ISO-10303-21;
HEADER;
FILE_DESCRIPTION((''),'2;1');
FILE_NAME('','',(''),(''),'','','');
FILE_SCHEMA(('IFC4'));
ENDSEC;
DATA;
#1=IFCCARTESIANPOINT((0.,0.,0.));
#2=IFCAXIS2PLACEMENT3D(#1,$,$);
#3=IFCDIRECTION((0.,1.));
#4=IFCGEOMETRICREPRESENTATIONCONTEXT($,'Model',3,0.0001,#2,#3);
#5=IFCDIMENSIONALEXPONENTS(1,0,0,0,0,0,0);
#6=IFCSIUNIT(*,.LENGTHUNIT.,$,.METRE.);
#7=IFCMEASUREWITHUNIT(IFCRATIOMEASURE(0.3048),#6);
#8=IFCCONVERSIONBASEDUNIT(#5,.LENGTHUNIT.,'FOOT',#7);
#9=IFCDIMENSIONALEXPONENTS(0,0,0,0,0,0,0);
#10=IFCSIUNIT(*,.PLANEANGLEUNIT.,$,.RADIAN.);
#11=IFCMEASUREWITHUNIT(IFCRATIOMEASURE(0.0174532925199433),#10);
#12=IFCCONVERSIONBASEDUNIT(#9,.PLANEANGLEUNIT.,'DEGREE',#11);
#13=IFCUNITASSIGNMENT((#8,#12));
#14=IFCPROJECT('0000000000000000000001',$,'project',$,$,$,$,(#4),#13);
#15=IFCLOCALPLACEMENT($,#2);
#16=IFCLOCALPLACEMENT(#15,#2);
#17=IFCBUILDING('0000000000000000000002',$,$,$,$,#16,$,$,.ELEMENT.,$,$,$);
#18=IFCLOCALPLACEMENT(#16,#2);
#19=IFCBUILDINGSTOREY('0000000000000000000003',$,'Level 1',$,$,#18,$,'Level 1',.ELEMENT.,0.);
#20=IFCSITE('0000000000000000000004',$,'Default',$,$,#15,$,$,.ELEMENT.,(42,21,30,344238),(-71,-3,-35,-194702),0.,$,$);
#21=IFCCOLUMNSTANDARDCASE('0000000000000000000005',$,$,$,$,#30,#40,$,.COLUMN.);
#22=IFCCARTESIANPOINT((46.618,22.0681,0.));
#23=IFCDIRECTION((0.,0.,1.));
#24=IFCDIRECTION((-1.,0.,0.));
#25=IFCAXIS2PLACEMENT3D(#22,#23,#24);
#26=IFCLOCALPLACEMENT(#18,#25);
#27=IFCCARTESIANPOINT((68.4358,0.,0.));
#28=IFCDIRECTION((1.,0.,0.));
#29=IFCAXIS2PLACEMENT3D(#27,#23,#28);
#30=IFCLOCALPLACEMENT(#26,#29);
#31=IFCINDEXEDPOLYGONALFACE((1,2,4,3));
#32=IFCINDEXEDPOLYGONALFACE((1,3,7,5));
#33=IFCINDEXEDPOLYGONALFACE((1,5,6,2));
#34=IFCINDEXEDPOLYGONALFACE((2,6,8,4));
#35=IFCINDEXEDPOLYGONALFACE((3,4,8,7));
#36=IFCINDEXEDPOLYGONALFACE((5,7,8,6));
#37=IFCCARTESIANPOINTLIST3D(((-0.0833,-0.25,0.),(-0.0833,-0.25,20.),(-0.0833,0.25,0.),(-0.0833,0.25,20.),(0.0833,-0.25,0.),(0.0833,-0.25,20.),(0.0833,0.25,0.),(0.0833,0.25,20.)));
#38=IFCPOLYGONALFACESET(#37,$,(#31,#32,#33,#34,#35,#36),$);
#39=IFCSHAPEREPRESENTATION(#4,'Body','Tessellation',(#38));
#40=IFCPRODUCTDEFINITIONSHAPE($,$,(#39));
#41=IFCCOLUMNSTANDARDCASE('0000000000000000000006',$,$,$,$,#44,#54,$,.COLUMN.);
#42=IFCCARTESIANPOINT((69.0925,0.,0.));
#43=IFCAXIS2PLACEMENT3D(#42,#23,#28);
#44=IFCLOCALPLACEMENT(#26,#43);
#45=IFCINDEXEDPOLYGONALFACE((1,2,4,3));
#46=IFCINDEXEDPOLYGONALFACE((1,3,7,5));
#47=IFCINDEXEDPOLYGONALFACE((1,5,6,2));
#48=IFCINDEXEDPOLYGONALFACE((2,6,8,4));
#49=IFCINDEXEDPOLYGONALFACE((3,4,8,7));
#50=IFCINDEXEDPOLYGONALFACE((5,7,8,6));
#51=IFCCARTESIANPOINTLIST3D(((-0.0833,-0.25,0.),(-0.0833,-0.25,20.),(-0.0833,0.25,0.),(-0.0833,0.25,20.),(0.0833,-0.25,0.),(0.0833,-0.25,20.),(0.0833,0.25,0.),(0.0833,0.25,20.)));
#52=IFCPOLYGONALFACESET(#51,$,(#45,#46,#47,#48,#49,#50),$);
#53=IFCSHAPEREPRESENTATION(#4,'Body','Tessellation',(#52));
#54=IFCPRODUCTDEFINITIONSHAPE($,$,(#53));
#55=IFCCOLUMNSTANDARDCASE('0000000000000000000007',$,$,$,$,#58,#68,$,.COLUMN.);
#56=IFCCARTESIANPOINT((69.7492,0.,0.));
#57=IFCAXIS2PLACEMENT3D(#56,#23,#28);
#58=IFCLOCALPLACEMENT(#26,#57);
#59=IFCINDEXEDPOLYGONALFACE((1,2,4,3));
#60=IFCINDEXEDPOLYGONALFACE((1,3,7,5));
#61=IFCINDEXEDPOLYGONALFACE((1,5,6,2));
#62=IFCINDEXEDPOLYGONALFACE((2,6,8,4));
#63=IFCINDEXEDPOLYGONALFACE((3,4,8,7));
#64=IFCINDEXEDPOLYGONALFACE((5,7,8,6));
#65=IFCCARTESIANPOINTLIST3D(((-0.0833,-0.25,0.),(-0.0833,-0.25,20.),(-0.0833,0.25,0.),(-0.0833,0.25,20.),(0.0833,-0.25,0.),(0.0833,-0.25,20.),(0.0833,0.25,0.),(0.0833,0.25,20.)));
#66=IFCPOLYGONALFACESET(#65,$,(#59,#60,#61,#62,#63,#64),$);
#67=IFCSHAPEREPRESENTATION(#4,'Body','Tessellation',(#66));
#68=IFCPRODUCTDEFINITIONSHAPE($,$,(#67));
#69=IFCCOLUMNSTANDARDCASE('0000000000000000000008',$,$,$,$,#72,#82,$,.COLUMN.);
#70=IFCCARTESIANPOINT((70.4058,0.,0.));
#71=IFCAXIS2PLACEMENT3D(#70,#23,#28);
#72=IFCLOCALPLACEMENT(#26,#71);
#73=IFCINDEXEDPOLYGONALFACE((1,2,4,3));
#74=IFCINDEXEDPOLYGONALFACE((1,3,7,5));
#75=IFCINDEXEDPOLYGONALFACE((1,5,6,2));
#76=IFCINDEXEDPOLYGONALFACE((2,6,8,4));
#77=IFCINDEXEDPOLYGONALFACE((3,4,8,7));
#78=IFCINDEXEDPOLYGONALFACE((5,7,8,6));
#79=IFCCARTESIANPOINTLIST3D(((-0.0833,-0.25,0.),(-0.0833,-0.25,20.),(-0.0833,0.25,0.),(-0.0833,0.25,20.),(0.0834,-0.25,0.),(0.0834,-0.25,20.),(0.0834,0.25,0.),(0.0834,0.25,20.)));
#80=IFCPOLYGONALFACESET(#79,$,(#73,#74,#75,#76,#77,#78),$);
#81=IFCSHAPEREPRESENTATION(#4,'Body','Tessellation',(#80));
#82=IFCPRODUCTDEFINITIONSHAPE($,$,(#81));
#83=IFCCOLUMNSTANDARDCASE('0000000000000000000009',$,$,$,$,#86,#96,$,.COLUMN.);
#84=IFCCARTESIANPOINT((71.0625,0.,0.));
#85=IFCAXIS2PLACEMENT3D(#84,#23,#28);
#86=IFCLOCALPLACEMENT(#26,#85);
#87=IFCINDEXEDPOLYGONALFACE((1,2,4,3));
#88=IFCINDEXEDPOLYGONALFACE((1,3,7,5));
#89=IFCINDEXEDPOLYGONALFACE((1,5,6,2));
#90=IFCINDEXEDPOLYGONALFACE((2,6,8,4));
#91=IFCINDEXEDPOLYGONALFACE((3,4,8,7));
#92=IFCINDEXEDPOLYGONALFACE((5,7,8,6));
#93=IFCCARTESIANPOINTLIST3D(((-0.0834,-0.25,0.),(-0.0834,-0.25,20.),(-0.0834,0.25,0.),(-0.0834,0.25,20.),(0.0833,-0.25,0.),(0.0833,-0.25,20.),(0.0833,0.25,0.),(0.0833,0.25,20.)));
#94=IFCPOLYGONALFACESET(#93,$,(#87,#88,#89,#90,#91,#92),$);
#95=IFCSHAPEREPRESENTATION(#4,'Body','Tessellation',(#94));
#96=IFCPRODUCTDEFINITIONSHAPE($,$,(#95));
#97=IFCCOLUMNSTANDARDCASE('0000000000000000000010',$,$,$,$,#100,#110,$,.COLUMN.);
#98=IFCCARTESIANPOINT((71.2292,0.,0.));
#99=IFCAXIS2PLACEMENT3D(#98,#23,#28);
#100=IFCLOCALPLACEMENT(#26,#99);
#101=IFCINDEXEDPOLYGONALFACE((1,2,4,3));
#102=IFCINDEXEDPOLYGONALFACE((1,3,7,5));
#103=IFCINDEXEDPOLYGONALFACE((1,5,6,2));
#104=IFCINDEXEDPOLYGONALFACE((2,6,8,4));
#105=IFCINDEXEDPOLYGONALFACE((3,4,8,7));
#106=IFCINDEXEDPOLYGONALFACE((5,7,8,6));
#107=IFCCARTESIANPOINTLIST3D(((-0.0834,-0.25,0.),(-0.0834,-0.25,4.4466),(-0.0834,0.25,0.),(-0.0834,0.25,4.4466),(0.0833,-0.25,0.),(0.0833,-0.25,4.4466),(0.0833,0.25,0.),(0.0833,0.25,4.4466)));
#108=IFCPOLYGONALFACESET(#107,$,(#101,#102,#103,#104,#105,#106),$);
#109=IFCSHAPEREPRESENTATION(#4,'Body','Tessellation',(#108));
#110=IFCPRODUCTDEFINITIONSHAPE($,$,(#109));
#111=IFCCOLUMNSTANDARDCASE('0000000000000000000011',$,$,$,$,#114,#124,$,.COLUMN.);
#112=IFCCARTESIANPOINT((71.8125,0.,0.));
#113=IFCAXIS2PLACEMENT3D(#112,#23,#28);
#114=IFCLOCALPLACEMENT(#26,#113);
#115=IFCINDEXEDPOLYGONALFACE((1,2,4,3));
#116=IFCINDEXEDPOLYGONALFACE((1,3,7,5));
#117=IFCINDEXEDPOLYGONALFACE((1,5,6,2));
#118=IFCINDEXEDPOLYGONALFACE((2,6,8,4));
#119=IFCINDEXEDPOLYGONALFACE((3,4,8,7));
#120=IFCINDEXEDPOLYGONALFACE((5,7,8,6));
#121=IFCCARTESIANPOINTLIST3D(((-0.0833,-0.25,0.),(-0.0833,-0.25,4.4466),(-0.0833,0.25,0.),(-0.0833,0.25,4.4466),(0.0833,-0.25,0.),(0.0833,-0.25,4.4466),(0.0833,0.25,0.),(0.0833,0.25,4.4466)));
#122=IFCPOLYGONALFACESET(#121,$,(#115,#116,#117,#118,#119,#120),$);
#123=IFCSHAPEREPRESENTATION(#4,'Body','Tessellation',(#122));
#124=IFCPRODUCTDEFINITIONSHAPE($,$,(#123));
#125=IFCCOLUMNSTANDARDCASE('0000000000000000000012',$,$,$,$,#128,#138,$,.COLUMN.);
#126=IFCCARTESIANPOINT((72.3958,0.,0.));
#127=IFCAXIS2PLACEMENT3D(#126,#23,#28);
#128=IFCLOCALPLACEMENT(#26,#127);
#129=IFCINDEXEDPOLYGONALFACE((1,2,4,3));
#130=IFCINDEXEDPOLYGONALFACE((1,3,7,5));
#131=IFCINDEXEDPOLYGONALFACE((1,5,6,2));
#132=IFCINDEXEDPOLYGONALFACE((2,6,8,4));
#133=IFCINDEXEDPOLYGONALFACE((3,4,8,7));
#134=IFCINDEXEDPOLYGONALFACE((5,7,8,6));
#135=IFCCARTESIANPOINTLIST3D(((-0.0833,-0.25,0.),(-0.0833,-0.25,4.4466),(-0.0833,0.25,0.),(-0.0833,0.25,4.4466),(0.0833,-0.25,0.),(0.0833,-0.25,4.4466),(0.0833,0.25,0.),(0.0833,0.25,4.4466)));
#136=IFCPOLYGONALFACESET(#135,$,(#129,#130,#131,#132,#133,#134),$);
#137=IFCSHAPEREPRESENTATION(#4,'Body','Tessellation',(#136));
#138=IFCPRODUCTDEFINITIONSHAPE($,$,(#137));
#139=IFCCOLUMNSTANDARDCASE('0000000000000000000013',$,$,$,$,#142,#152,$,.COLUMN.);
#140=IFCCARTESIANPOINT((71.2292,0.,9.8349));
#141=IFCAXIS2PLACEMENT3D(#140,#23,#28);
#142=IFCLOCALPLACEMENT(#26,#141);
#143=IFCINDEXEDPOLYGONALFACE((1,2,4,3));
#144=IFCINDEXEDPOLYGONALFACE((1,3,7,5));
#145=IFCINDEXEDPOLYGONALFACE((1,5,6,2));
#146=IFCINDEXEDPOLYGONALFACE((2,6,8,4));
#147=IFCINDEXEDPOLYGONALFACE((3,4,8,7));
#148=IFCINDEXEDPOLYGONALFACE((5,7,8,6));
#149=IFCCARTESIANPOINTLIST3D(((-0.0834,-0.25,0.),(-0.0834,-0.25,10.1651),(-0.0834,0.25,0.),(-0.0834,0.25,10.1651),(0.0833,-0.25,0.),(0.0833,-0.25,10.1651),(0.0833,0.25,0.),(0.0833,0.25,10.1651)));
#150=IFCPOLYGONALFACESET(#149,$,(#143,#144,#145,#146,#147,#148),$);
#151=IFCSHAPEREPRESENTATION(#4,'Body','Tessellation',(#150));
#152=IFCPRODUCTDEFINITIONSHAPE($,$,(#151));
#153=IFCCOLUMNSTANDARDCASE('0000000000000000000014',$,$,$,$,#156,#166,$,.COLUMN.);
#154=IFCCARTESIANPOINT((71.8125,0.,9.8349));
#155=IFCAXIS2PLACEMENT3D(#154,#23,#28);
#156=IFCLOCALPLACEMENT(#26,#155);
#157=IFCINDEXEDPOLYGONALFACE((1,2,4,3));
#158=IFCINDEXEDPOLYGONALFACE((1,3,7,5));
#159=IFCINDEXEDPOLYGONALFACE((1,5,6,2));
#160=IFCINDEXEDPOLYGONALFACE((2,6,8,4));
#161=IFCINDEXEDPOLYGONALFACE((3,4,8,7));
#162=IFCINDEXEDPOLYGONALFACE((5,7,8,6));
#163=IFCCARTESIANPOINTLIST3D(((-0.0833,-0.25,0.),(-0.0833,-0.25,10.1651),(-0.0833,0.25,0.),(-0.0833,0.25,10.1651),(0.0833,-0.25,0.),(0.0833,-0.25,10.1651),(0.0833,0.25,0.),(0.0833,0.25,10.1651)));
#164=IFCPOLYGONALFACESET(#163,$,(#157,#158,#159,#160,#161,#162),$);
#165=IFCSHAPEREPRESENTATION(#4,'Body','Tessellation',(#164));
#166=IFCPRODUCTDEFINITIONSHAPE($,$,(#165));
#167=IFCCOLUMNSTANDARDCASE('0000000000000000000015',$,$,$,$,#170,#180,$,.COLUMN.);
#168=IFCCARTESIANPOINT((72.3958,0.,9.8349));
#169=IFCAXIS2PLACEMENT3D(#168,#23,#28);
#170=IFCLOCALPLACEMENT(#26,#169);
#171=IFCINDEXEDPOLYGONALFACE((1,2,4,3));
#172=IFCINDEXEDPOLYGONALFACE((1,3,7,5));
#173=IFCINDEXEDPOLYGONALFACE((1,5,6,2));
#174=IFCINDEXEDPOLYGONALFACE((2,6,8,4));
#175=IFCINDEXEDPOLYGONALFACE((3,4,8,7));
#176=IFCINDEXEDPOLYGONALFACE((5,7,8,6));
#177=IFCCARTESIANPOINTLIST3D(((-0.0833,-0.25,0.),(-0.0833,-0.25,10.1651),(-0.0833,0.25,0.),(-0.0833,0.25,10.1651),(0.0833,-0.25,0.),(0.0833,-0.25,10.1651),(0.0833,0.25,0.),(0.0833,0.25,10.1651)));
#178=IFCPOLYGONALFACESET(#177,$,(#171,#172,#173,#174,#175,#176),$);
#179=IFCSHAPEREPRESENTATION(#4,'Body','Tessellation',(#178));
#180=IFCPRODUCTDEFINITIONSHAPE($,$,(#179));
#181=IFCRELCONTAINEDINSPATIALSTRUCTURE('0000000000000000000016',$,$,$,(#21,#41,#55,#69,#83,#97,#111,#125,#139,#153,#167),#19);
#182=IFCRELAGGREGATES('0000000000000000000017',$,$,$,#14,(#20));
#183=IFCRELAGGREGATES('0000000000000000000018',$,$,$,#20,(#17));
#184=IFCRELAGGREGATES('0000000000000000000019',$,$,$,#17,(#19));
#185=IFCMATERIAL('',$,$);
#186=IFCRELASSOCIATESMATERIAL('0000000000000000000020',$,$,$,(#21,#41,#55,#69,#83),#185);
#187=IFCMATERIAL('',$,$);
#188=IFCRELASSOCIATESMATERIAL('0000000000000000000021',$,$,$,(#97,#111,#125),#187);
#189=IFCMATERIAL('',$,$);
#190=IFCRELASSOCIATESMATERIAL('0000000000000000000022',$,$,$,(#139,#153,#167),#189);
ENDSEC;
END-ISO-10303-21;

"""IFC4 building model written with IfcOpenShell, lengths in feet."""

from ifc_helpers import new_model, entity, si_unit, converted_unit, direction, frame, origin, place, context, project, spatial, rectangle, extrude, material, element, save


model = new_model("IFC4")

# Units and contexts
model_context = context("Model", 3, precision=0.0001, world=origin(), true_north=direction((0.0, 1.0)))
ifc_project = project(units=[converted_unit("LENGTHUNIT", "FOOT", entity("IfcRatioMeasure", 0.3048), si_unit("LENGTHUNIT", "METRE"), dimensions=[1, 0, 0, 0, 0, 0, 0]), converted_unit("PLANEANGLEUNIT", "DEGREE", entity("IfcRatioMeasure", 0.0174532925199433), si_unit("PLANEANGLEUNIT", "RADIAN"), dimensions=[0, 0, 0, 0, 0, 0, 0])], contexts=[model_context])

# Site, building, storey
site_placement = place(None, origin())
site = spatial("IfcSite", under=ifc_project, at=site_placement, Name="Default", CompositionType="ELEMENT", RefLatitude=(42, 21, 30, 344238), RefLongitude=(-71, -3, -35, -194702), RefElevation=0.0)
building_placement = place(site_placement, origin())
building = spatial("IfcBuilding", under=site, at=building_placement, CompositionType="ELEMENT")
storey_placement = place(building_placement, origin())
storey = spatial("IfcBuildingStorey", under=building, at=storey_placement, Name="Level 1", LongName="Level 1", CompositionType="ELEMENT", Elevation=0.0)

# Columns
placement = place(storey_placement, frame((46.618, 22.0681, 0.0), z_axis=(0.0, 0.0, 1.0), x_axis=(-1.0, 0.0, 0.0)))
ifc_material_1 = material(Name="")
for number, where, z_axis, x_axis in (
    (1, (68.4358, 0.0, 0.0), (0.0, 0.0, 1.0), (1.0, 0.0, 0.0)),
    (2, (69.0925, 0.0, 0.0), (0.0, 0.0, 1.0), (1.0, 0.0, 0.0)),
    (3, (69.7492, 0.0, 0.0), (0.0, 0.0, 1.0), (1.0, 0.0, 0.0)),
    (4, (70.4058, 0.0, 0.0), (0.0, 0.0, 1.0), (1.0, 0.0, 0.0)),
    (5, (71.0625, 0.0, 0.0), (0.0, 0.0, 1.0), (1.0, 0.0, 0.0)),
):
    element("IfcColumnStandardCase", number, at=place(placement, frame(where, z_axis=z_axis, x_axis=x_axis)), inside=storey, material=ifc_material_1, PredefinedType="COLUMN", context=model_context, shape_type="SweptSolid", body=[
        extrude(rectangle(XDim=0.1667, YDim=0.5), origin(), (0.0, 0.0, 1.0), 20.0),
    ])
ifc_material_2 = material(Name="")
for number, where, z_axis, x_axis in (
    (6, (71.2292, 0.0, 0.0), (0.0, 0.0, 1.0), (1.0, 0.0, 0.0)),
    (7, (71.8125, 0.0, 0.0), (0.0, 0.0, 1.0), (1.0, 0.0, 0.0)),
    (8, (72.3958, 0.0, 0.0), (0.0, 0.0, 1.0), (1.0, 0.0, 0.0)),
):
    element("IfcColumnStandardCase", number, at=place(placement, frame(where, z_axis=z_axis, x_axis=x_axis)), inside=storey, material=ifc_material_2, PredefinedType="COLUMN", context=model_context, shape_type="SweptSolid", body=[
        extrude(rectangle(XDim=0.1667, YDim=0.5), origin(), (0.0, 0.0, 1.0), 4.4466),
    ])
ifc_material_3 = material(Name="")
for number, where, z_axis, x_axis in (
    (9, (71.2292, 0.0, 9.8349), (0.0, 0.0, 1.0), (1.0, 0.0, 0.0)),
    (10, (71.8125, 0.0, 9.8349), (0.0, 0.0, 1.0), (1.0, 0.0, 0.0)),
    (11, (72.3958, 0.0, 9.8349), (0.0, 0.0, 1.0), (1.0, 0.0, 0.0)),
):
    element("IfcColumnStandardCase", number, at=place(placement, frame(where, z_axis=z_axis, x_axis=x_axis)), inside=storey, material=ifc_material_3, PredefinedType="COLUMN", context=model_context, shape_type="SweptSolid", body=[
        extrude(rectangle(XDim=0.1667, YDim=0.5), origin(), (0.0, 0.0, 1.0), 10.1651),
    ])

save(model, "model.ifc")
